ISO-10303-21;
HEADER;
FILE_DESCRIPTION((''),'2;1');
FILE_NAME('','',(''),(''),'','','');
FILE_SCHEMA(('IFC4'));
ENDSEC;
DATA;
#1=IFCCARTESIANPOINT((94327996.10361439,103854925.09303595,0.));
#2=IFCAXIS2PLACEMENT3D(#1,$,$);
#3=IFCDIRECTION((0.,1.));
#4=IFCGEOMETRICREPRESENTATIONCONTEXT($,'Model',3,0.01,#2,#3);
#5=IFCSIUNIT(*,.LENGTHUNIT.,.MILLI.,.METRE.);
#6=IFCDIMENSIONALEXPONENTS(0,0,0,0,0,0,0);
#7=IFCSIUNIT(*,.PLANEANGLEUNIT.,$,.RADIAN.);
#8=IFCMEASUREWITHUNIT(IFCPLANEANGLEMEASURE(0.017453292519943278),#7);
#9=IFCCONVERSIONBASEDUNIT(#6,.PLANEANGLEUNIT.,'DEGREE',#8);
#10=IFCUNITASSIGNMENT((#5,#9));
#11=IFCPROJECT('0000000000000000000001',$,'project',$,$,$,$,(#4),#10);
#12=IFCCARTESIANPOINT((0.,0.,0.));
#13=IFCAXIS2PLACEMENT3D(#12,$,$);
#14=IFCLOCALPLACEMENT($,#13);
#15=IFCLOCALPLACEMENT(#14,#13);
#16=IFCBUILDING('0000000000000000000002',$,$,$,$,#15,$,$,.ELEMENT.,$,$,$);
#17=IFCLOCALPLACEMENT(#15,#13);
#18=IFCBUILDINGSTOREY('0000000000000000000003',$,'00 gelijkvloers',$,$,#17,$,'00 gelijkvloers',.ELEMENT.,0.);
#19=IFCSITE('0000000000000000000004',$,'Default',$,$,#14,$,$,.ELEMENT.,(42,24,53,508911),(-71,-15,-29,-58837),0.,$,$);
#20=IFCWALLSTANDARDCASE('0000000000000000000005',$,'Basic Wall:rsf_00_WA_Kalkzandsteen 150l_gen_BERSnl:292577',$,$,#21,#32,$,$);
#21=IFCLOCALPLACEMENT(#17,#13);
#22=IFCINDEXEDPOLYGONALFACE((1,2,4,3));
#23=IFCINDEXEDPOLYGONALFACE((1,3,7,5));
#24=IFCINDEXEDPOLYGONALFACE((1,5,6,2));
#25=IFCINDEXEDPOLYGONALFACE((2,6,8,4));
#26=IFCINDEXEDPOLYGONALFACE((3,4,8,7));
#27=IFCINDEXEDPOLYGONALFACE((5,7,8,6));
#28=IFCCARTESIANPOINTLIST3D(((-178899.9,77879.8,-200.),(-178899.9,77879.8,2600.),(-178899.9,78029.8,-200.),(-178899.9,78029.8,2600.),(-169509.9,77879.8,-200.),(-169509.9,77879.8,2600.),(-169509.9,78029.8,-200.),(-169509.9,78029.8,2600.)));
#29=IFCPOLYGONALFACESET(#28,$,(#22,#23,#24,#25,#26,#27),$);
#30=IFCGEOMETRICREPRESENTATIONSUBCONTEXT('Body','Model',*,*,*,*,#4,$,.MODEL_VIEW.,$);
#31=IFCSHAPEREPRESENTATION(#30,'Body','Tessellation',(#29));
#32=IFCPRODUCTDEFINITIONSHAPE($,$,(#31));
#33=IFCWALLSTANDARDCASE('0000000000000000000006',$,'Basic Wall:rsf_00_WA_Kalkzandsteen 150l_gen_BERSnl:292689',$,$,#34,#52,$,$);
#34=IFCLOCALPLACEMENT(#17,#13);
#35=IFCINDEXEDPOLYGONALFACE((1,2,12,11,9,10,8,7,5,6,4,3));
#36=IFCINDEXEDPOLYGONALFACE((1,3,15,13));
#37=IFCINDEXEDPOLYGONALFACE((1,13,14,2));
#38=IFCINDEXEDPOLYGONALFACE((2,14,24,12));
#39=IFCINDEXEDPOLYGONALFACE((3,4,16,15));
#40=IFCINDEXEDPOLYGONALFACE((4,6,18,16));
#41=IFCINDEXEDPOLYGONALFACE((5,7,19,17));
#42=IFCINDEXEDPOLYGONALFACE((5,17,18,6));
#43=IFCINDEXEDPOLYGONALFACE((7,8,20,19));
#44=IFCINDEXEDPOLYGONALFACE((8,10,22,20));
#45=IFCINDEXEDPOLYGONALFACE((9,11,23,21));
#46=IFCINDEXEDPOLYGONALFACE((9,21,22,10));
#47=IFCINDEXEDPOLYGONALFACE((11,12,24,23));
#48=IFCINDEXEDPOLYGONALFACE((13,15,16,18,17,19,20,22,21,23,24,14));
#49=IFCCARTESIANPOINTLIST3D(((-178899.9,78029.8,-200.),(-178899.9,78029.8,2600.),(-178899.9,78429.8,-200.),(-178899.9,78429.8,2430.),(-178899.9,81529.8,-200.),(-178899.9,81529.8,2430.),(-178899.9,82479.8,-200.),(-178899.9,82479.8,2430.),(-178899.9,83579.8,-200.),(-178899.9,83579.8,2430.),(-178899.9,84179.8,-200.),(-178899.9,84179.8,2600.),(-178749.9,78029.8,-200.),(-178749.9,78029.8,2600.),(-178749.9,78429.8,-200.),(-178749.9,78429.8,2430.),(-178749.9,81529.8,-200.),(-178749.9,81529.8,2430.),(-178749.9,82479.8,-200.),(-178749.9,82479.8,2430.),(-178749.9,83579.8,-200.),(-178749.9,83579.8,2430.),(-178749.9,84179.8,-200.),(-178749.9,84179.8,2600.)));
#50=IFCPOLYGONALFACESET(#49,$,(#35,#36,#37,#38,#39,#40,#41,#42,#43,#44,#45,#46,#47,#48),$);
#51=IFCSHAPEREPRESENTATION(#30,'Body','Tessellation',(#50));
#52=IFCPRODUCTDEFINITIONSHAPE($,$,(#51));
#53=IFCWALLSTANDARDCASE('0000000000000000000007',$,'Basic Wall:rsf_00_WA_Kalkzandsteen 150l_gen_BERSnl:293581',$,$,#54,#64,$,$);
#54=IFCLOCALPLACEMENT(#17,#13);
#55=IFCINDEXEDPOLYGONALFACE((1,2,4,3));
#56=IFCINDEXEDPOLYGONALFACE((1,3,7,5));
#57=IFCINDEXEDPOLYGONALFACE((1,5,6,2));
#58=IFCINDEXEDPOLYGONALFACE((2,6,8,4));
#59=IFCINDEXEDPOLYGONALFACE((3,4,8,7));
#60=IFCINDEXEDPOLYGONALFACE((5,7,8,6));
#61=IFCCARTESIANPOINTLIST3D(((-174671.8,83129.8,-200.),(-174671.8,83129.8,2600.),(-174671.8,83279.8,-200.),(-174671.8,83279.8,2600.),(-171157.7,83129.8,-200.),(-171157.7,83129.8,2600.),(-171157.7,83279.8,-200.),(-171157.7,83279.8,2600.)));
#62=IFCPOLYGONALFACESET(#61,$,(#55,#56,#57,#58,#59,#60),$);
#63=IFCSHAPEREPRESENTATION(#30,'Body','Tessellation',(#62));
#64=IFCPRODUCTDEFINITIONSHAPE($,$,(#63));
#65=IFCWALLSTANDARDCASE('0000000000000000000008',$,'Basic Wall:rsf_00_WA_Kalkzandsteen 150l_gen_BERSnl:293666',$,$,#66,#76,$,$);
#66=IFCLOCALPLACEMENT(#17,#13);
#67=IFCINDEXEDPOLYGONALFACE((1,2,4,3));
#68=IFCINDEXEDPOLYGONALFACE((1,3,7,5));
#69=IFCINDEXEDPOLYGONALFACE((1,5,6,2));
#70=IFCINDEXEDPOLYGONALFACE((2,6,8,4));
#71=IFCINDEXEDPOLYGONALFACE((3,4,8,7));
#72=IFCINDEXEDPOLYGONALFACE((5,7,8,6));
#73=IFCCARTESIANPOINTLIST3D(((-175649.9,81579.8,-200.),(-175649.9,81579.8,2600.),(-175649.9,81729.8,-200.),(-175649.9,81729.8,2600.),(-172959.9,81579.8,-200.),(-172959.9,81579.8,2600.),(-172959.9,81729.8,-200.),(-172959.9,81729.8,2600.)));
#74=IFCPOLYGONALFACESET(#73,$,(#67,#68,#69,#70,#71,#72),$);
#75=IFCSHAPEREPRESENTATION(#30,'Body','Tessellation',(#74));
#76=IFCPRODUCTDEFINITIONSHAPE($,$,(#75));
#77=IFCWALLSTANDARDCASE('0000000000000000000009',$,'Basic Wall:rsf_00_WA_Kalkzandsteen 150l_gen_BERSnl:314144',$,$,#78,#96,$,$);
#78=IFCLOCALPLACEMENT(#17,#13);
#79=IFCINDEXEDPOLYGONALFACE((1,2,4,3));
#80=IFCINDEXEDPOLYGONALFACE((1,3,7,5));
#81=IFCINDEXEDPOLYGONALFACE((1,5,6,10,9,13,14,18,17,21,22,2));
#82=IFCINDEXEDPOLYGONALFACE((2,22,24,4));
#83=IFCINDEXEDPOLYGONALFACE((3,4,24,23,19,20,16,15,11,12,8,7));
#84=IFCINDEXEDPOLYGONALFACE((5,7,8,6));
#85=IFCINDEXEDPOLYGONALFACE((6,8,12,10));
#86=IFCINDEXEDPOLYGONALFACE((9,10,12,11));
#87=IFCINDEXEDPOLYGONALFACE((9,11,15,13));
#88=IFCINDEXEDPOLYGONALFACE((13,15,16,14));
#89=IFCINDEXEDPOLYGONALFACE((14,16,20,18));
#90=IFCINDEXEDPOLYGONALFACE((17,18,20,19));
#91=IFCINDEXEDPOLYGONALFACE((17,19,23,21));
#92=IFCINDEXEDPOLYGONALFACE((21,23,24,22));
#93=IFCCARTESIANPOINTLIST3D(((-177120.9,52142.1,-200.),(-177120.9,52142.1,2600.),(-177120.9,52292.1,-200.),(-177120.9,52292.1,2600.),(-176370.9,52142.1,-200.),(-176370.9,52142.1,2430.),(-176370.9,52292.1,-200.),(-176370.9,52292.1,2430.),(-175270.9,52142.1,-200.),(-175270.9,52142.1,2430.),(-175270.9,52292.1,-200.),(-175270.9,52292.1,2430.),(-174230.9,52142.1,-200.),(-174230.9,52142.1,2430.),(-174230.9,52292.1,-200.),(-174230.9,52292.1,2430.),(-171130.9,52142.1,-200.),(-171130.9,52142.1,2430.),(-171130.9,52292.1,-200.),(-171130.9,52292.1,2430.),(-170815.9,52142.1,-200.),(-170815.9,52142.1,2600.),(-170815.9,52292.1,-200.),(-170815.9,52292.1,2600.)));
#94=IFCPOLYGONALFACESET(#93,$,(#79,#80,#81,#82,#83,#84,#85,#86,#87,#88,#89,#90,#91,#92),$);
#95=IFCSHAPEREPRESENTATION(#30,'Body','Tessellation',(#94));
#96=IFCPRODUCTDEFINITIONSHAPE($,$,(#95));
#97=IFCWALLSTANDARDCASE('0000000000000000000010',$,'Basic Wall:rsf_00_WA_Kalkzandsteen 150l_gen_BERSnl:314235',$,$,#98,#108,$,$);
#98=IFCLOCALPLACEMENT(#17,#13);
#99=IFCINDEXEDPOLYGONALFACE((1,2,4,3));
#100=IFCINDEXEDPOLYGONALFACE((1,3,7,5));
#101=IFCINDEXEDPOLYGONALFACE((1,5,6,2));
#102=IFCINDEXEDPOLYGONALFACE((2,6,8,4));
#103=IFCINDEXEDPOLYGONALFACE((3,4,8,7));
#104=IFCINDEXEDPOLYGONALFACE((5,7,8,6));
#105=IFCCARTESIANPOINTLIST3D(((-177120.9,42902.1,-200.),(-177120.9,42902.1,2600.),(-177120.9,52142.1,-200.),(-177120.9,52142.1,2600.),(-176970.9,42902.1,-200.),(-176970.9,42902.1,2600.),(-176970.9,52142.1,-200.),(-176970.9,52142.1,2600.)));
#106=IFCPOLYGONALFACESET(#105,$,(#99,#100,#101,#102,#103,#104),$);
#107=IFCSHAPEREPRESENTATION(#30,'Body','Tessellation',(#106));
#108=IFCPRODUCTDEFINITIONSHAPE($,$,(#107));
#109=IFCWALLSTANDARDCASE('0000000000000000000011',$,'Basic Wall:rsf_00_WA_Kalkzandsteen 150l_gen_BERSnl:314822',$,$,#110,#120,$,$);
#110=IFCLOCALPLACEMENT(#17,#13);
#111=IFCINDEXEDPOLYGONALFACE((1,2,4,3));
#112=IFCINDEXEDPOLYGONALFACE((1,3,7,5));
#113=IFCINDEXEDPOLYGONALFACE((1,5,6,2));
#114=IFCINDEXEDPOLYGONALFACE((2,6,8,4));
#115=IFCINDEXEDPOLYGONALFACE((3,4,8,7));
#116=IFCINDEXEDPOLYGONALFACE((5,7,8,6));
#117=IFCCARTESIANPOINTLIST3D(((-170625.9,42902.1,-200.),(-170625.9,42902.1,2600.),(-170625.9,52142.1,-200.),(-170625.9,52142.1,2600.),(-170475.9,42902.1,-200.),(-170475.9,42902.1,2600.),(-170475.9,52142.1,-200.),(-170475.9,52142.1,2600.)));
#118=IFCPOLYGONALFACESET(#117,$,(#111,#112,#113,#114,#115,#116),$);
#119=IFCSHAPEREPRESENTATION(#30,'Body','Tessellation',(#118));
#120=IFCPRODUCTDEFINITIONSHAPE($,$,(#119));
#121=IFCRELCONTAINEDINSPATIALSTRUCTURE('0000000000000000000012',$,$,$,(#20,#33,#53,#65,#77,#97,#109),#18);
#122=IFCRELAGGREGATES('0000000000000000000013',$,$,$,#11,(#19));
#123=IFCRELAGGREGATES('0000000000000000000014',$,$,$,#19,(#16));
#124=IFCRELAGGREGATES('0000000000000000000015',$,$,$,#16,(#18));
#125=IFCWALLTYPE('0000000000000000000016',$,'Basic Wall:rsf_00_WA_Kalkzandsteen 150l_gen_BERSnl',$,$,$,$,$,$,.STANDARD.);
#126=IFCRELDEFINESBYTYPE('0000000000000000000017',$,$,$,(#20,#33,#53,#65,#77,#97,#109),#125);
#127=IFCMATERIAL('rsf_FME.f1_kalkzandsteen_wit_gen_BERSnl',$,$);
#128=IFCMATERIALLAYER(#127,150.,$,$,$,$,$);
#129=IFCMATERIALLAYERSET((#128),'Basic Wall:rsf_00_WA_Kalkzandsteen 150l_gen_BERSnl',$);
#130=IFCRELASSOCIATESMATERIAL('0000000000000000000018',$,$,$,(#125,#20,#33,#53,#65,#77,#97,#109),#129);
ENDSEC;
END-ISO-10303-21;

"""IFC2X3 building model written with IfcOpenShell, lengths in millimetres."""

from ifc_helpers import new_model, entity, si_unit, converted_unit, direction, frame, frame_2d, origin, place, context, subcontext, project, spatial, polyline, rectangle, extrude, clip, bounded_halfspace, material, layer, layer_set, layer_usage, type_object, element, save


model = new_model("IFC2X3")

# Units and contexts
model_context = context("Model", 3, precision=0.01, world=frame((94327996.10361439, 103854925.09303595, 0.0)), true_north=direction((0.0, 1.0)))
body_context = subcontext(model_context, "Body", "Model", "MODEL_VIEW")
ifc_project = project(units=[si_unit("LENGTHUNIT", "METRE", prefix="MILLI"), converted_unit("PLANEANGLEUNIT", "DEGREE", entity("IfcPlaneAngleMeasure", 0.017453292519943278), si_unit("PLANEANGLEUNIT", "RADIAN"), dimensions=[0, 0, 0, 0, 0, 0, 0])], contexts=[model_context])

# Site, building, storey
site_placement = place(None, origin())
site = spatial("IfcSite", under=ifc_project, at=site_placement, Name="Default", CompositionType="ELEMENT", RefLatitude=(42, 24, 53, 508911), RefLongitude=(-71, -15, -29, -58837), RefElevation=0.0)
building_placement = place(site_placement, origin())
building = spatial("IfcBuilding", under=site, at=building_placement, CompositionType="ELEMENT")
storey_placement = place(building_placement, origin())
storey = spatial("IfcBuildingStorey", under=building, at=storey_placement, Name="00 gelijkvloers", LongName="00 gelijkvloers", CompositionType="ELEMENT", Elevation=0.0)

# Shared definitions
ifc_material_1 = material(Name="rsf_FME.f1_kalkzandsteen_wit_gen_BERSnl")
ifc_layer_1 = layer(ifc_material_1, 150.0)
ifc_layer_set_1 = layer_set([ifc_layer_1], Name="Basic Wall:rsf_00_WA_Kalkzandsteen 150l_gen_BERSnl")
wall_type_1 = type_object("IfcWallType", Name="Basic Wall:rsf_00_WA_Kalkzandsteen 150l_gen_BERSnl", PredefinedType="STANDARD", material=ifc_layer_set_1)

# Wall
ifc_layer_usage_1 = layer_usage(ifc_layer_set_1, "AXIS2", "POSITIVE", -75.0)
wall_1_placement = place(storey_placement, frame((-169509.9, 77954.8, -200.0), z_axis=(0.0, 0.0, 1.0), x_axis=(-1.0, 0.0, 0.0)))
element("IfcWallStandardCase", 1, at=wall_1_placement, inside=storey, type_object=wall_type_1, material=ifc_layer_usage_1, Name="Basic Wall:rsf_00_WA_Kalkzandsteen 150l_gen_BERSnl:292577", context=body_context, shape_type="Clipping", body=[
    clip(extrude(rectangle(XDim=9390.0, YDim=150.0, at=frame_2d((4695.0, 0.0), x_axis=(-1.0, 0.0))), origin(), (0.0, 0.0, 1.0), 2800.0), bounded_halfspace(frame((0.0, -75.0, 2800.0), z_axis=(0.0, 0.0, -1.0), x_axis=(0.0, -1.0, 0.0)), True, frame((0.0, -75.0, 2800.0)), polyline([(0.0, 0.0), (9240.0, 0.0), (9390.0, 0.0), (9390.0, 150.0), (0.0, 150.0), (0.0, 0.0)]))),
])

# Wall, openings
ifc_layer_usage_2 = layer_usage(ifc_layer_set_1, "AXIS2", "POSITIVE", -75.0)
wall_2_placement = place(storey_placement, frame((-178824.9, 78029.8, -200.0), z_axis=(0.0, 0.0, 1.0), x_axis=(0.0, 1.0, 0.0)))
wall_2 = element("IfcWallStandardCase", 2, at=wall_2_placement, inside=storey, type_object=wall_type_1, material=ifc_layer_usage_2, Name="Basic Wall:rsf_00_WA_Kalkzandsteen 150l_gen_BERSnl:292689", context=body_context, shape_type="Clipping", body=[
    clip(extrude(rectangle(XDim=6150.0, YDim=150.0, at=frame_2d((3075.0, 0.0), x_axis=(1.0, 0.0))), origin(), (0.0, 0.0, 1.0), 2800.0), bounded_halfspace(frame((0.0, -75.0, 2800.0), z_axis=(0.0, 0.0, -1.0), x_axis=(1.0, 0.0, 0.0)), True, frame((0.0, -75.0, 2800.0)), polyline([(0.0, 0.0), (6150.0, 0.0), (6150.0, 150.0), (0.0, 150.0), (0.0, 0.0)]))),
])
opening_1_placement = place(wall_2_placement, frame((-78029.8, -178824.9, 200.0), z_axis=(0.0, 0.0, 1.0), x_axis=(0.0, -1.0, 0.0)))
element("IfcOpeningElement", 3, at=opening_1_placement, cuts=wall_2, ObjectType="Opening", context=body_context, shape_type="SweptSolid", body=[
    extrude(rectangle(XDim=2630.0, YDim=3100.0, at=frame_2d((0.0, 0.0), x_axis=(1.0, 0.0))), frame((-177375.9, 79979.8, 1115.0), z_axis=(-1.0, 0.0, 0.0), x_axis=(0.0, 0.0, 1.0)), (0.0, 0.0, 1.0), 3048.0),
])
opening_2_placement = place(wall_2_placement, frame((-78029.8, -178824.9, 200.0), z_axis=(0.0, 0.0, 1.0), x_axis=(0.0, -1.0, 0.0)))
element("IfcOpeningElement", 4, at=opening_2_placement, cuts=wall_2, ObjectType="Opening", context=body_context, shape_type="SweptSolid", body=[
    extrude(rectangle(XDim=2630.0, YDim=1100.0, at=frame_2d((0.0, 0.0), x_axis=(0.0, 1.0))), frame((-177225.9, 83029.8, 1115.0), z_axis=(-1.0, 0.0, 0.0), x_axis=(0.0, -1.0, 0.0)), (0.0, 0.0, 1.0), 3048.0),
])

# Walls
ifc_layer_usage_3 = layer_usage(ifc_layer_set_1, "AXIS2", "POSITIVE", -75.0)
wall_3_placement = place(storey_placement, frame((-171157.7, 83204.8, -200.0), z_axis=(0.0, 0.0, 1.0), x_axis=(-1.0, 0.0, 0.0)))
element("IfcWallStandardCase", 5, at=wall_3_placement, inside=storey, type_object=wall_type_1, material=ifc_layer_usage_3, Name="Basic Wall:rsf_00_WA_Kalkzandsteen 150l_gen_BERSnl:293581", context=body_context, shape_type="Clipping", body=[
    clip(clip(extrude(rectangle(XDim=3514.2, YDim=150.0, at=frame_2d((1757.1, 0.0), x_axis=(-1.0, 0.0))), origin(), (0.0, 0.0, 1.0), 2800.0), bounded_halfspace(frame((3514.2, -75.0, 0.0), z_axis=(0.0, 0.0, 1.0), x_axis=(-1.0, 0.0, 0.0)), True, frame((3514.2, -75.0, 0.0)), polyline([(0.0, 0.0), (0.0, 150.0), (-3514.2, 150.0), (-3514.2, 0.0), (0.0, 0.0)]))), bounded_halfspace(frame((0.0, -75.0, 2800.0), z_axis=(0.0, 0.0, -1.0), x_axis=(0.0, -1.0, 0.0)), True, frame((0.0, -75.0, 2800.0)), polyline([(0.0, 0.0), (3514.2, 0.0), (3514.2, 150.0), (0.0, 150.0), (0.0, 0.0)]))),
])
ifc_layer_usage_4 = layer_usage(ifc_layer_set_1, "AXIS2", "NEGATIVE", 75.0)
wall_4_placement = place(storey_placement, frame((-175649.9, 81654.8, -200.0)))
element("IfcWallStandardCase", 6, at=wall_4_placement, inside=storey, type_object=wall_type_1, material=ifc_layer_usage_4, Name="Basic Wall:rsf_00_WA_Kalkzandsteen 150l_gen_BERSnl:293666", context=body_context, shape_type="Clipping", body=[
    clip(clip(extrude(rectangle(XDim=2690.0, YDim=150.0, at=frame_2d((1345.0, 0.0), x_axis=(-1.0, 0.0))), origin(), (0.0, 0.0, 1.0), 2800.0), bounded_halfspace(frame((2690.0, -75.0, 0.0)), True, frame((2690.0, -75.0, 0.0)), polyline([(0.0, 0.0), (0.0, 150.0), (-2690.0, 150.0), (-2690.0, 0.0), (0.0, 0.0)]))), bounded_halfspace(frame((0.0, -75.0, 2800.0), z_axis=(0.0, 0.0, -1.0), x_axis=(0.0, 1.0, 0.0)), True, frame((0.0, -75.0, 2800.0)), polyline([(0.0, 0.0), (2690.0, 0.0), (2690.0, 150.0), (0.0, 150.0), (0.0, 0.0)]))),
])

# Wall, openings
ifc_layer_usage_5 = layer_usage(ifc_layer_set_1, "AXIS2", "NEGATIVE", 75.0)
wall_5_placement = place(storey_placement, frame((-170815.9, 52217.1, -200.0), z_axis=(0.0, 0.0, 1.0), x_axis=(-1.0, 0.0, 0.0)))
wall_5 = element("IfcWallStandardCase", 7, at=wall_5_placement, inside=storey, type_object=wall_type_1, material=ifc_layer_usage_5, Name="Basic Wall:rsf_00_WA_Kalkzandsteen 150l_gen_BERSnl:314144", context=body_context, shape_type="Clipping", body=[
    clip(extrude(rectangle(XDim=6305.0, YDim=150.0, at=frame_2d((3152.5, 0.0), x_axis=(-1.0, 0.0))), origin(), (0.0, 0.0, 1.0), 2800.0), bounded_halfspace(frame((0.0, -75.0, 2800.0), z_axis=(0.0, 0.0, -1.0), x_axis=(-1.0, 0.0, 0.0)), True, frame((0.0, -75.0, 2800.0)), polyline([(0.0, 0.0), (6305.0, 0.0), (6305.0, 150.0), (6155.0, 150.0), (0.0, 150.0), (0.0, 0.0)]))),
])
opening_3_placement = place(wall_5_placement, frame((-170815.9, 52217.1, 200.0), z_axis=(0.0, 0.0, 1.0), x_axis=(-1.0, 0.0, 0.0)))
element("IfcOpeningElement", 8, at=opening_3_placement, cuts=wall_5, ObjectType="Opening", context=body_context, shape_type="SweptSolid", body=[
    extrude(rectangle(XDim=2630.0, YDim=3100.0, at=frame_2d((0.0, 0.0), x_axis=(0.0, 1.0))), frame((-172680.9, 53816.1, 1115.0), z_axis=(0.0, -1.0, 0.0), x_axis=(1.0, 0.0, 0.0)), (0.0, 0.0, 1.0), 3048.0),
])
opening_4_placement = place(wall_5_placement, frame((-170815.9, 52217.1, 200.0), z_axis=(0.0, 0.0, 1.0), x_axis=(-1.0, 0.0, 0.0)))
element("IfcOpeningElement", 9, at=opening_4_placement, cuts=wall_5, ObjectType="Opening", context=body_context, shape_type="SweptSolid", body=[
    extrude(rectangle(XDim=2630.0, YDim=1100.0, at=frame_2d((0.0, 0.0), x_axis=(0.0, 1.0))), frame((-175820.9, 53816.1, 1115.0), z_axis=(0.0, -1.0, 0.0), x_axis=(1.0, 0.0, 0.0)), (0.0, 0.0, 1.0), 3048.0),
])

# Walls
ifc_layer_usage_6 = layer_usage(ifc_layer_set_1, "AXIS2", "NEGATIVE", 75.0)
wall_6_placement = place(storey_placement, frame((-177045.9, 52142.1, -200.0), z_axis=(0.0, 0.0, 1.0), x_axis=(0.0, -1.0, 0.0)))
element("IfcWallStandardCase", 10, at=wall_6_placement, inside=storey, type_object=wall_type_1, material=ifc_layer_usage_6, Name="Basic Wall:rsf_00_WA_Kalkzandsteen 150l_gen_BERSnl:314235", context=body_context, shape_type="Clipping", body=[
    clip(extrude(rectangle(XDim=9240.0, YDim=150.0, at=frame_2d((4620.0, 0.0), x_axis=(-1.0, 0.0))), origin(), (0.0, 0.0, 1.0), 2800.0), bounded_halfspace(frame((0.0, -75.0, 2800.0), z_axis=(0.0, 0.0, -1.0), x_axis=(0.0, 1.0, 0.0)), True, frame((0.0, -75.0, 2800.0)), polyline([(0.0, 0.0), (850.0, 0.0), (9240.0, 0.0), (9240.0, 150.0), (0.0, 150.0), (0.0, 0.0)]))),
])
ifc_layer_usage_7 = layer_usage(ifc_layer_set_1, "AXIS2", "NEGATIVE", 75.0)
wall_7_placement = place(storey_placement, frame((-170550.9, 52142.1, -200.0), z_axis=(0.0, 0.0, 1.0), x_axis=(0.0, -1.0, 0.0)))
element("IfcWallStandardCase", 11, at=wall_7_placement, inside=storey, type_object=wall_type_1, material=ifc_layer_usage_7, Name="Basic Wall:rsf_00_WA_Kalkzandsteen 150l_gen_BERSnl:314822", context=body_context, shape_type="Clipping", body=[
    clip(extrude(rectangle(XDim=9240.0, YDim=150.0, at=frame_2d((4620.0, 0.0), x_axis=(-1.0, 0.0))), origin(), (0.0, 0.0, 1.0), 2800.0), bounded_halfspace(frame((0.0, -75.0, 2800.0), z_axis=(0.0, 0.0, -1.0), x_axis=(0.0, 1.0, 0.0)), True, frame((0.0, -75.0, 2800.0)), polyline([(0.0, 0.0), (9240.0, 0.0), (9240.0, 150.0), (0.0, 150.0), (0.0, 0.0)]))),
])

save(model, "model.ifc")
